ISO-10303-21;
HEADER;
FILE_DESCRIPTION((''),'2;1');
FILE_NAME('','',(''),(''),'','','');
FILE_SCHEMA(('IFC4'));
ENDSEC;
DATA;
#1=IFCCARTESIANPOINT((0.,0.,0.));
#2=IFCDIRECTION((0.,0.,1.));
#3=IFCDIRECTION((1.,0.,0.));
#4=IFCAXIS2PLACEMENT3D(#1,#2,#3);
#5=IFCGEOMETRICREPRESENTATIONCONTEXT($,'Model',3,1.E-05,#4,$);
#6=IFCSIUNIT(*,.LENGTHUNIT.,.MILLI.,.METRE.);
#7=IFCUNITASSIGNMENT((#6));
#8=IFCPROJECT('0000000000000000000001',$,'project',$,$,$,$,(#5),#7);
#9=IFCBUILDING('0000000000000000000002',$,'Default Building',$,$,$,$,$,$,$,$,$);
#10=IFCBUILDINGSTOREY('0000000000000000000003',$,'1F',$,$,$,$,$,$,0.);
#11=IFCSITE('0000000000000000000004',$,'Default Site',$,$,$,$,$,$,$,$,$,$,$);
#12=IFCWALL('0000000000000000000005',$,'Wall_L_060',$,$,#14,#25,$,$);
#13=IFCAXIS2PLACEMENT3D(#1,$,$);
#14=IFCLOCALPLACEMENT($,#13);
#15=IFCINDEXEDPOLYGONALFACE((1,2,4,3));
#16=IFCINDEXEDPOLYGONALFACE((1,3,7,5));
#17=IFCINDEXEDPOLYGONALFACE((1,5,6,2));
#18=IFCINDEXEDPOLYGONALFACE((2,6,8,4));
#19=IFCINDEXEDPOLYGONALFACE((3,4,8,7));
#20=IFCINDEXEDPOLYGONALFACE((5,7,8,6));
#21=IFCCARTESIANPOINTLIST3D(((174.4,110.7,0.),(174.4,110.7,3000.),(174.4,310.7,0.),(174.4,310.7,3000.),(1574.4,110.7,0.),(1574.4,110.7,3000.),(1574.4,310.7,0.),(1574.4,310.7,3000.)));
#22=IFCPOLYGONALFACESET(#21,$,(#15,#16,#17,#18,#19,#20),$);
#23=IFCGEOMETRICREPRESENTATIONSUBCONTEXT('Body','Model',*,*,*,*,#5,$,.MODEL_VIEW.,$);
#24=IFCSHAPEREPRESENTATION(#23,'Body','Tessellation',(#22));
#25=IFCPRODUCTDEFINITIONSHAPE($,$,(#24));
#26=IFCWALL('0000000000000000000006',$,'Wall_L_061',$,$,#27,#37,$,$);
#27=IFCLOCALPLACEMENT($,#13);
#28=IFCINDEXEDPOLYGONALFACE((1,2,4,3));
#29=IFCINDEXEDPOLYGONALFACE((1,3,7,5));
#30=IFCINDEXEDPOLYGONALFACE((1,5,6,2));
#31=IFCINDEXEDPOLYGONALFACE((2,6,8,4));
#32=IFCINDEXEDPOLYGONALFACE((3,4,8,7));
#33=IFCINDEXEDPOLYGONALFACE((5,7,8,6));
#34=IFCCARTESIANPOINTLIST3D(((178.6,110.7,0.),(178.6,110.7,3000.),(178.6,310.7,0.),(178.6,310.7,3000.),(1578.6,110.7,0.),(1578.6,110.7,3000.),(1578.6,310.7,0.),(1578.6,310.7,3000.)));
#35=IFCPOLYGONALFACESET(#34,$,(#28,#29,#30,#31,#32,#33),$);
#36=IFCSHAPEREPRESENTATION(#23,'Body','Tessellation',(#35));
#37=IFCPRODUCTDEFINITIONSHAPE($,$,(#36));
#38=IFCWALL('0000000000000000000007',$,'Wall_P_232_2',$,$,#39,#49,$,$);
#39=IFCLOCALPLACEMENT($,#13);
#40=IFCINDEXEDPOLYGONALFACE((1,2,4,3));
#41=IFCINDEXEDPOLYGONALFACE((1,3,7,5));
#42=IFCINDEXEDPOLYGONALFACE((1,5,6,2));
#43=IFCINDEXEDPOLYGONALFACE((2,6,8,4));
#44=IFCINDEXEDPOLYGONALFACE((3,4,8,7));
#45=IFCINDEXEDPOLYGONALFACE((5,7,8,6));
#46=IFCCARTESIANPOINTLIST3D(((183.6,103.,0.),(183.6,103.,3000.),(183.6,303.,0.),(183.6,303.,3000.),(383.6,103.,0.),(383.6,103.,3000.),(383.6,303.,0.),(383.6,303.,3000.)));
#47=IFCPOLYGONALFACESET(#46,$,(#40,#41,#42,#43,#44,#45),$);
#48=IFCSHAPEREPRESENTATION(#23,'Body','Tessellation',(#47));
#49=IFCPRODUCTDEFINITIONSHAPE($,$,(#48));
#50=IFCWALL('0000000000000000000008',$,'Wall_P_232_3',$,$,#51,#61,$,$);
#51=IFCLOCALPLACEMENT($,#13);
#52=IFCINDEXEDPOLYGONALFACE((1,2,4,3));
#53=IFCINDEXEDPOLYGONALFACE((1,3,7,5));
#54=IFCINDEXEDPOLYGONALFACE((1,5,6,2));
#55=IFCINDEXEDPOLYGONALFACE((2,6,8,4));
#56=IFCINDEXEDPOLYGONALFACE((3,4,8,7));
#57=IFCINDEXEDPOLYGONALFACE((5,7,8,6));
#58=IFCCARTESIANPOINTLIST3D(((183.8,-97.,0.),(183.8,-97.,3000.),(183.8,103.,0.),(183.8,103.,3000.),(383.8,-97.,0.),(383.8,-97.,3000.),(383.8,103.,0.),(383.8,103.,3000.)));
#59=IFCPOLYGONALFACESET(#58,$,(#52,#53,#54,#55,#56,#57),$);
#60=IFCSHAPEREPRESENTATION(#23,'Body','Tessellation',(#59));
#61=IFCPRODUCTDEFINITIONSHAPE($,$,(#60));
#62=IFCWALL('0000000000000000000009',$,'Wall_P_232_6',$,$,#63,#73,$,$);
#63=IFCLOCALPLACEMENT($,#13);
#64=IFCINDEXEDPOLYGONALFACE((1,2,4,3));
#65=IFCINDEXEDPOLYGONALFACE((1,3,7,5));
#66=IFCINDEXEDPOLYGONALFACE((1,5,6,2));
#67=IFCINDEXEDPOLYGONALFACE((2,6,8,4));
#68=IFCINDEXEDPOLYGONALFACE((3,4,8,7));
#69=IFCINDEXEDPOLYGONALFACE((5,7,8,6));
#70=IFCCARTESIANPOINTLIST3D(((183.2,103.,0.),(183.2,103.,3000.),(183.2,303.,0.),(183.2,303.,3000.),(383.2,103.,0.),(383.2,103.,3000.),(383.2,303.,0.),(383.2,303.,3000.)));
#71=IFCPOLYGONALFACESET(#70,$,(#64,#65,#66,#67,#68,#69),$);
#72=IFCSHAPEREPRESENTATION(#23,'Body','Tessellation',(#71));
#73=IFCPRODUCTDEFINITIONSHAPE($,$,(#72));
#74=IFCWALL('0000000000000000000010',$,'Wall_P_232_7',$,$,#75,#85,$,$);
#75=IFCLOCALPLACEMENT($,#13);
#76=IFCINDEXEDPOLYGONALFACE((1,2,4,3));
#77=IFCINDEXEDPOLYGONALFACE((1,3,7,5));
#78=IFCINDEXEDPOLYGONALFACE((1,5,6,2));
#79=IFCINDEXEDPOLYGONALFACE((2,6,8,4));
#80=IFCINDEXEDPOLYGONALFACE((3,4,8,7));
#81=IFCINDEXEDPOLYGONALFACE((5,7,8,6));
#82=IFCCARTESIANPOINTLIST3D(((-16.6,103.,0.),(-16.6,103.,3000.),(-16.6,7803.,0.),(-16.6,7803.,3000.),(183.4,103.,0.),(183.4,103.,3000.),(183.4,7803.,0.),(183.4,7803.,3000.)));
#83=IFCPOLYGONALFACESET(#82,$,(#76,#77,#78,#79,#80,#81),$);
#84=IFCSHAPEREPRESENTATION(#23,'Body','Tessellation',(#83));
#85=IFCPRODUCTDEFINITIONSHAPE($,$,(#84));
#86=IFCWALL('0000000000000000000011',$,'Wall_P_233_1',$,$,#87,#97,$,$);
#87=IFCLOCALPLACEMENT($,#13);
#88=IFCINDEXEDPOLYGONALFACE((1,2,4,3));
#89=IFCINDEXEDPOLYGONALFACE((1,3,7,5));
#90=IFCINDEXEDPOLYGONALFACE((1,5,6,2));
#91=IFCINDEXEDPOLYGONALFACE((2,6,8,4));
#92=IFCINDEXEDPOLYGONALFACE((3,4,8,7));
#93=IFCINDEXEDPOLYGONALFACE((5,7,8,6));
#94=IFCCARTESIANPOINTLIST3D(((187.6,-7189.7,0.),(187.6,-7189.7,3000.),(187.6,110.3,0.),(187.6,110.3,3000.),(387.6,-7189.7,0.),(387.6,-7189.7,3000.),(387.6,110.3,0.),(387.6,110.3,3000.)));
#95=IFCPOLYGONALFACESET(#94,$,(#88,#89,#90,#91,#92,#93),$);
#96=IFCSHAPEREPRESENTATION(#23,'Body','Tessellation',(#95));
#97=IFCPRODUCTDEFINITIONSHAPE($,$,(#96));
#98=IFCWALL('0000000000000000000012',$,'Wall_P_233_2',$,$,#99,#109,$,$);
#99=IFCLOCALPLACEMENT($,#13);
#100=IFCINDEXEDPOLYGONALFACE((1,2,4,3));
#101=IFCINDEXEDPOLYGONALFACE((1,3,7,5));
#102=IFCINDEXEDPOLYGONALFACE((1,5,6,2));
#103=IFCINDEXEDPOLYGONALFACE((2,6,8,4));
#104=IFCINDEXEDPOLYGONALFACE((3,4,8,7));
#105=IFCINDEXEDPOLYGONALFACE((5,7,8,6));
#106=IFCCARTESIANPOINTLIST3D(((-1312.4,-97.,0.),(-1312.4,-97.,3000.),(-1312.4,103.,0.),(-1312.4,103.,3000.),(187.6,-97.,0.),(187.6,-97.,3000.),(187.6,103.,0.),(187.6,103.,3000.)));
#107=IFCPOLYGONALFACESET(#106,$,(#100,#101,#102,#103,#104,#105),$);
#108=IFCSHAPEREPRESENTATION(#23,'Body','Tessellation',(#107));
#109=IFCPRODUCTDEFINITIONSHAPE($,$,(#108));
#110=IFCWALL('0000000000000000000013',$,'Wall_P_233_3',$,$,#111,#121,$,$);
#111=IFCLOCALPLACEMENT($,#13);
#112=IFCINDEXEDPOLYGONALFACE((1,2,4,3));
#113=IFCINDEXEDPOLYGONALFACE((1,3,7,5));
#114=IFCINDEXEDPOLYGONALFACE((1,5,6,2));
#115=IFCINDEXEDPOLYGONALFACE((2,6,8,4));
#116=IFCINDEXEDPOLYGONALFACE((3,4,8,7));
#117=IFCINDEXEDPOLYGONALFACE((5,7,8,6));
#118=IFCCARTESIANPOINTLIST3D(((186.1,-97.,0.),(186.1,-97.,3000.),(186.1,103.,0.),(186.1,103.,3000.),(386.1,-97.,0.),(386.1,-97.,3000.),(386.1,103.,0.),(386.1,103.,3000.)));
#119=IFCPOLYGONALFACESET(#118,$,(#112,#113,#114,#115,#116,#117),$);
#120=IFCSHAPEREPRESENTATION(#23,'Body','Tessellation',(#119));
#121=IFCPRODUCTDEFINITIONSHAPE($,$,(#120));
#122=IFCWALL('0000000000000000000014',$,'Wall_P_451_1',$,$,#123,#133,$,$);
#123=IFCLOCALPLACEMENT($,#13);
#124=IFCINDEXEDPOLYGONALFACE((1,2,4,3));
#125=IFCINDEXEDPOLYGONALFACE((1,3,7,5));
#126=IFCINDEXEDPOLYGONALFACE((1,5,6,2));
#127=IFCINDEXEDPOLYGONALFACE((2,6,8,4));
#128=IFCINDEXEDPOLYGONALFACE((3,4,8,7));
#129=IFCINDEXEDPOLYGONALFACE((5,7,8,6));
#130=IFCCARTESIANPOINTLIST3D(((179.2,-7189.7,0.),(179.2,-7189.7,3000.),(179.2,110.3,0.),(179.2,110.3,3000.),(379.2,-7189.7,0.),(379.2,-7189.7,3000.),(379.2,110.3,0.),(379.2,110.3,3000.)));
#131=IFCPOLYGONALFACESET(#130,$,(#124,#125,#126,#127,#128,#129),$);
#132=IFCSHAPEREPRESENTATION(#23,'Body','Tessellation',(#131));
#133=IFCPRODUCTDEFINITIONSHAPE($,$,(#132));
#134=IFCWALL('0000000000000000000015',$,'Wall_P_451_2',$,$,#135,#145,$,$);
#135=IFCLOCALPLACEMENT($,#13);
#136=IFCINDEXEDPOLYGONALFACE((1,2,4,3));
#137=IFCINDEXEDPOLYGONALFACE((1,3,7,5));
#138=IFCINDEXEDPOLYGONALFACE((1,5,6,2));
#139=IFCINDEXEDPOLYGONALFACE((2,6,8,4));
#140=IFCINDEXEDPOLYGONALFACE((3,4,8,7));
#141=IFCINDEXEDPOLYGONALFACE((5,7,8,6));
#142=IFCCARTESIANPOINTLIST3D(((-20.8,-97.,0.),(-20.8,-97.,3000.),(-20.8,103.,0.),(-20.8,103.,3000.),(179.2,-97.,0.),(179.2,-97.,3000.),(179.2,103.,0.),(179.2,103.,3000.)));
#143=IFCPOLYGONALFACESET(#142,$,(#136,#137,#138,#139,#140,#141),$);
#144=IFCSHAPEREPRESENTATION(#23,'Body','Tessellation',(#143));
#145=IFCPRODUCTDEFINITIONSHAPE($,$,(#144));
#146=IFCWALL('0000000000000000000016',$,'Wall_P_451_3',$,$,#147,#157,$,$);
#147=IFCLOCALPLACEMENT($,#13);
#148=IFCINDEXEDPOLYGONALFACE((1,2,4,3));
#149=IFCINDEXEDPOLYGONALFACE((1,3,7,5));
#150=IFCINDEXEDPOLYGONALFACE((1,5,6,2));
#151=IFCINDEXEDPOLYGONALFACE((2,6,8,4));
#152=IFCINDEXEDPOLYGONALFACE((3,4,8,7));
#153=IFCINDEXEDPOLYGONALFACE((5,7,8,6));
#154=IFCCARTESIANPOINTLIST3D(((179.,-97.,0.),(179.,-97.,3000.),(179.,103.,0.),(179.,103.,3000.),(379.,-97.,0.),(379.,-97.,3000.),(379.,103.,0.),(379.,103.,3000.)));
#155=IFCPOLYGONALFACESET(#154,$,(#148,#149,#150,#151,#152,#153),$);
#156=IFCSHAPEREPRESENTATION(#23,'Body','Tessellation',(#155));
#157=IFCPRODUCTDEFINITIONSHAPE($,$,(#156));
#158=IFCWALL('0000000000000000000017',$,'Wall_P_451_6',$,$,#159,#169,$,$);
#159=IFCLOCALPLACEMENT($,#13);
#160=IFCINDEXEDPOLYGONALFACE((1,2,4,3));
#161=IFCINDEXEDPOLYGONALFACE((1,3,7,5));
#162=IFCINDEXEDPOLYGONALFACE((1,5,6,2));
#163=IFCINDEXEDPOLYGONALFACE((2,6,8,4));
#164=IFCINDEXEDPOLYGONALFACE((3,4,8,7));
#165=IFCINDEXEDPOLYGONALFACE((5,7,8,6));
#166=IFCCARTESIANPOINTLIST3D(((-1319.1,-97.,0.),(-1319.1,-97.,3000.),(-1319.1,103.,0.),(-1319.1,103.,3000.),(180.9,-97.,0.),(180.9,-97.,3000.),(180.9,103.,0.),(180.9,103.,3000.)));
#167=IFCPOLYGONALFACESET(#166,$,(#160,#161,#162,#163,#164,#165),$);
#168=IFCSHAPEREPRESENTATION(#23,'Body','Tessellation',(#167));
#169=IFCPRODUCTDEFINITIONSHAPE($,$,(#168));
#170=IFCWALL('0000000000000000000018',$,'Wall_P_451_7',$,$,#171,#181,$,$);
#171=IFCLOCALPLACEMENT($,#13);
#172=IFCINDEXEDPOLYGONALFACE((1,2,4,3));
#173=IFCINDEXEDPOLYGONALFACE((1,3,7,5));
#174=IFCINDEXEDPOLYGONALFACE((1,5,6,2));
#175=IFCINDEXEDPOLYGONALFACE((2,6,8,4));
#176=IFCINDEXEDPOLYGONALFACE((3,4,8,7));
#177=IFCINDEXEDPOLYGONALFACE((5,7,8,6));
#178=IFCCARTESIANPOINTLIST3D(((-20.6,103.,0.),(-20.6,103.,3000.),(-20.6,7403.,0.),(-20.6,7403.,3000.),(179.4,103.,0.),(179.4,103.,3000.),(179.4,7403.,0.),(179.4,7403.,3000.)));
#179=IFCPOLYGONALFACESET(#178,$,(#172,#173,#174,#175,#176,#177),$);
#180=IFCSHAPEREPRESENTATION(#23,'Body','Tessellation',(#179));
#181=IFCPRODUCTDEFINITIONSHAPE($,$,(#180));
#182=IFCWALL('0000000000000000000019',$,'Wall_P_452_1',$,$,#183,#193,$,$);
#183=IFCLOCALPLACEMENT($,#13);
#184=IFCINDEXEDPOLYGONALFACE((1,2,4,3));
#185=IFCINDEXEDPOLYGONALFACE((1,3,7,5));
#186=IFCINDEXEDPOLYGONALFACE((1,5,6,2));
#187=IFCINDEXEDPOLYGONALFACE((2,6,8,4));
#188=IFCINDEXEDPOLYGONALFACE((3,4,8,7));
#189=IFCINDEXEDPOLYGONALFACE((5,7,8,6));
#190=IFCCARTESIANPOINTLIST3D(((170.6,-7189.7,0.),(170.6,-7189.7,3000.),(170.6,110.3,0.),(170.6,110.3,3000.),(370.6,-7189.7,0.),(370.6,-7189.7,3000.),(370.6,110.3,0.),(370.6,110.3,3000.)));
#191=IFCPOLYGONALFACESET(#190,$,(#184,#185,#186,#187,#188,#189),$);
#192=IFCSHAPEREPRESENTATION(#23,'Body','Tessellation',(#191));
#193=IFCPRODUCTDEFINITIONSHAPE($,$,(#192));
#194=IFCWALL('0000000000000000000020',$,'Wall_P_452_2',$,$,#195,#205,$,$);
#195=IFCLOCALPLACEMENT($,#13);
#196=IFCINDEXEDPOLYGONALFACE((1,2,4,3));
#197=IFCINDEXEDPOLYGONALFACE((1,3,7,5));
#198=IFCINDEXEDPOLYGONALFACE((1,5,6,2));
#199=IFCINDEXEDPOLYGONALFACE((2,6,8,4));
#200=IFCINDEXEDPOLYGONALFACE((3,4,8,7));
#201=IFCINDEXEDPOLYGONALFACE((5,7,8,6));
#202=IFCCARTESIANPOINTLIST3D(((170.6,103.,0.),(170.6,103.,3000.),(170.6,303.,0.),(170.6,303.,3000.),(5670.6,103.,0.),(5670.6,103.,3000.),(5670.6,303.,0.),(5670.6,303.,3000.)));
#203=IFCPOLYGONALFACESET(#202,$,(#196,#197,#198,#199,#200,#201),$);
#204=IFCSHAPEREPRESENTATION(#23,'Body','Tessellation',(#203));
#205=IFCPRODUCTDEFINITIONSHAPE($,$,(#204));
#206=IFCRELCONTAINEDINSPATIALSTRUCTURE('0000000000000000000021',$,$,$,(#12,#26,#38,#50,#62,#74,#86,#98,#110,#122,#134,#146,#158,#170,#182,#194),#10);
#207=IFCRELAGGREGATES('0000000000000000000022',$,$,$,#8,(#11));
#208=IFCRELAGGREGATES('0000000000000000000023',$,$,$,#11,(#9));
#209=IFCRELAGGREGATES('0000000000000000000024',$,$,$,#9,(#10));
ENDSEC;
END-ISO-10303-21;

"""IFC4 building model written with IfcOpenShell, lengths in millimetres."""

from ifc_helpers import new_model, si_unit, frame, origin_with_axes, place, context, subcontext, project, spatial, indexed_curve, outline, extrude, element, save


model = new_model("IFC4")

# Units and contexts
model_context = context("Model", 3, precision=1e-05, world=origin_with_axes())
body_context = subcontext(model_context, "Body", "Model", "MODEL_VIEW")
ifc_project = project(units=[si_unit("LENGTHUNIT", "METRE", prefix="MILLI")], contexts=[model_context])

# Site, building, storey
site = spatial("IfcSite", under=ifc_project, Name="Default Site")
building = spatial("IfcBuilding", under=site, Name="Default Building")
storey = spatial("IfcBuildingStorey", under=building, Name="1F", Elevation=0.0)

# Walls
for number, where, z_axis, x_axis, name in (
    (1, (174.4, 110.7, 0.0), (0.0, 0.0, 1.0), (1.0, 0.0, 0.0), "Wall_L_060"),
    (2, (178.6, 110.7, 0.0), (0.0, 0.0, 1.0), (1.0, 0.0, 0.0), "Wall_L_061"),
):
    element("IfcWall", number, at=place(None, frame(where, z_axis=z_axis, x_axis=x_axis)), inside=storey, Name=name, context=body_context, shape_type="SweptSolid", body=[
        extrude(outline(indexed_curve([(0.0, 0.0), (0.0, 200.0), (1400.0, 200.0), (1400.0, 0.0), (0.0, 0.0)], self_intersect=False)), origin_with_axes(), (0.0, 0.0, 1.0), 3000.0),
    ])
wall_1_placement = place(None, frame((183.6, 103.0, 0.0), z_axis=(0.0, 0.0, 1.0), x_axis=(1.0, 0.0, 0.0)))
element("IfcWall", 3, at=wall_1_placement, inside=storey, Name="Wall_P_232_2", context=body_context, shape_type="SweptSolid", body=[
    extrude(outline(indexed_curve([(0.0, 0.0), (0.0, 200.0), (200.0, 200.0), (200.0, 0.0), (0.0, 0.0)], self_intersect=False)), origin_with_axes(), (0.0, 0.0, 1.0), 3000.0),
])
wall_2_placement = place(None, frame((183.8, 103.0, 0.0), z_axis=(0.0, 0.0, 1.0), x_axis=(0.0, -1.0, 0.0)))
element("IfcWall", 4, at=wall_2_placement, inside=storey, Name="Wall_P_232_3", context=body_context, shape_type="SweptSolid", body=[
    extrude(outline(indexed_curve([(0.0, 0.0), (0.0, 200.0), (200.0, 200.0), (200.0, 0.0), (0.0, 0.0)], self_intersect=False)), origin_with_axes(), (0.0, 0.0, 1.0), 3000.0),
])
wall_3_placement = place(None, frame((183.2, 103.0, 0.0), z_axis=(0.0, 0.0, 1.0), x_axis=(1.0, 0.0, 0.0)))
element("IfcWall", 5, at=wall_3_placement, inside=storey, Name="Wall_P_232_6", context=body_context, shape_type="SweptSolid", body=[
    extrude(outline(indexed_curve([(0.0, 0.0), (0.0, 200.0), (200.0, 200.0), (200.0, 0.0), (0.0, 0.0)], self_intersect=False)), origin_with_axes(), (0.0, 0.0, 1.0), 3000.0),
])
wall_4_placement = place(None, frame((183.4, 103.0, 0.0), z_axis=(0.0, 0.0, 1.0), x_axis=(0.0, 1.0, 0.0)))
element("IfcWall", 6, at=wall_4_placement, inside=storey, Name="Wall_P_232_7", context=body_context, shape_type="SweptSolid", body=[
    extrude(outline(indexed_curve([(0.0, 0.0), (0.0, 200.0), (7700.0, 200.0), (7700.0, 0.0), (0.0, 0.0)], self_intersect=False)), origin_with_axes(), (0.0, 0.0, 1.0), 3000.0),
])
wall_5_placement = place(None, frame((187.6, 110.3, 0.0), z_axis=(0.0, 0.0, 1.0), x_axis=(0.0, -1.0, 0.0)))
element("IfcWall", 7, at=wall_5_placement, inside=storey, Name="Wall_P_233_1", context=body_context, shape_type="SweptSolid", body=[
    extrude(outline(indexed_curve([(0.0, 0.0), (0.0, 200.0), (7300.0, 200.0), (7300.0, 0.0), (0.0, 0.0)], self_intersect=False)), origin_with_axes(), (0.0, 0.0, 1.0), 3000.0),
])
wall_6_placement = place(None, frame((187.6, 103.0, 0.0), z_axis=(0.0, 0.0, 1.0), x_axis=(-1.0, 0.0, 0.0)))
element("IfcWall", 8, at=wall_6_placement, inside=storey, Name="Wall_P_233_2", context=body_context, shape_type="SweptSolid", body=[
    extrude(outline(indexed_curve([(0.0, 0.0), (0.0, 200.0), (1500.0, 200.0), (1500.0, 0.0), (0.0, 0.0)], self_intersect=False)), origin_with_axes(), (0.0, 0.0, 1.0), 3000.0),
])
wall_7_placement = place(None, frame((186.1, 103.0, 0.0), z_axis=(0.0, 0.0, 1.0), x_axis=(0.0, -1.0, 0.0)))
element("IfcWall", 9, at=wall_7_placement, inside=storey, Name="Wall_P_233_3", context=body_context, shape_type="SweptSolid", body=[
    extrude(outline(indexed_curve([(0.0, 0.0), (0.0, 200.0), (200.0, 200.0), (200.0, 0.0), (0.0, 0.0)], self_intersect=False)), origin_with_axes(), (0.0, 0.0, 1.0), 3000.0),
])
wall_8_placement = place(None, frame((179.2, 110.3, 0.0), z_axis=(0.0, 0.0, 1.0), x_axis=(0.0, -1.0, 0.0)))
element("IfcWall", 10, at=wall_8_placement, inside=storey, Name="Wall_P_451_1", context=body_context, shape_type="SweptSolid", body=[
    extrude(outline(indexed_curve([(0.0, 0.0), (0.0, 200.0), (7300.0, 200.0), (7300.0, 0.0), (0.0, 0.0)], self_intersect=False)), origin_with_axes(), (0.0, 0.0, 1.0), 3000.0),
])
wall_9_placement = place(None, frame((179.2, 103.0, 0.0), z_axis=(0.0, 0.0, 1.0), x_axis=(-1.0, 0.0, 0.0)))
element("IfcWall", 11, at=wall_9_placement, inside=storey, Name="Wall_P_451_2", context=body_context, shape_type="SweptSolid", body=[
    extrude(outline(indexed_curve([(0.0, 0.0), (0.0, 200.0), (200.0, 200.0), (200.0, 0.0), (0.0, 0.0)], self_intersect=False)), origin_with_axes(), (0.0, 0.0, 1.0), 3000.0),
])
wall_10_placement = place(None, frame((179.0, 103.0, 0.0), z_axis=(0.0, 0.0, 1.0), x_axis=(0.0, -1.0, 0.0)))
element("IfcWall", 12, at=wall_10_placement, inside=storey, Name="Wall_P_451_3", context=body_context, shape_type="SweptSolid", body=[
    extrude(outline(indexed_curve([(0.0, 0.0), (0.0, 200.0), (200.0, 200.0), (200.0, 0.0), (0.0, 0.0)], self_intersect=False)), origin_with_axes(), (0.0, 0.0, 1.0), 3000.0),
])
wall_11_placement = place(None, frame((180.9, 103.0, 0.0), z_axis=(0.0, 0.0, 1.0), x_axis=(-1.0, 0.0, 0.0)))
element("IfcWall", 13, at=wall_11_placement, inside=storey, Name="Wall_P_451_6", context=body_context, shape_type="SweptSolid", body=[
    extrude(outline(indexed_curve([(0.0, 0.0), (0.0, 200.0), (1500.0, 200.0), (1500.0, 0.0), (0.0, 0.0)], self_intersect=False)), origin_with_axes(), (0.0, 0.0, 1.0), 3000.0),
])
wall_12_placement = place(None, frame((179.4, 103.0, 0.0), z_axis=(0.0, 0.0, 1.0), x_axis=(0.0, 1.0, 0.0)))
element("IfcWall", 14, at=wall_12_placement, inside=storey, Name="Wall_P_451_7", context=body_context, shape_type="SweptSolid", body=[
    extrude(outline(indexed_curve([(0.0, 0.0), (0.0, 200.0), (7300.0, 200.0), (7300.0, 0.0), (0.0, 0.0)], self_intersect=False)), origin_with_axes(), (0.0, 0.0, 1.0), 3000.0),
])
wall_13_placement = place(None, frame((170.6, 110.3, 0.0), z_axis=(0.0, 0.0, 1.0), x_axis=(0.0, -1.0, 0.0)))
element("IfcWall", 15, at=wall_13_placement, inside=storey, Name="Wall_P_452_1", context=body_context, shape_type="SweptSolid", body=[
    extrude(outline(indexed_curve([(0.0, 0.0), (0.0, 200.0), (7300.0, 200.0), (7300.0, 0.0), (0.0, 0.0)], self_intersect=False)), origin_with_axes(), (0.0, 0.0, 1.0), 3000.0),
])
wall_14_placement = place(None, frame((170.6, 103.0, 0.0), z_axis=(0.0, 0.0, 1.0), x_axis=(1.0, 0.0, 0.0)))
element("IfcWall", 16, at=wall_14_placement, inside=storey, Name="Wall_P_452_2", context=body_context, shape_type="SweptSolid", body=[
    extrude(outline(indexed_curve([(0.0, 0.0), (0.0, 200.0), (5500.0, 200.0), (5500.0, 0.0), (0.0, 0.0)], self_intersect=False)), origin_with_axes(), (0.0, 0.0, 1.0), 3000.0),
])

save(model, "model.ifc")
